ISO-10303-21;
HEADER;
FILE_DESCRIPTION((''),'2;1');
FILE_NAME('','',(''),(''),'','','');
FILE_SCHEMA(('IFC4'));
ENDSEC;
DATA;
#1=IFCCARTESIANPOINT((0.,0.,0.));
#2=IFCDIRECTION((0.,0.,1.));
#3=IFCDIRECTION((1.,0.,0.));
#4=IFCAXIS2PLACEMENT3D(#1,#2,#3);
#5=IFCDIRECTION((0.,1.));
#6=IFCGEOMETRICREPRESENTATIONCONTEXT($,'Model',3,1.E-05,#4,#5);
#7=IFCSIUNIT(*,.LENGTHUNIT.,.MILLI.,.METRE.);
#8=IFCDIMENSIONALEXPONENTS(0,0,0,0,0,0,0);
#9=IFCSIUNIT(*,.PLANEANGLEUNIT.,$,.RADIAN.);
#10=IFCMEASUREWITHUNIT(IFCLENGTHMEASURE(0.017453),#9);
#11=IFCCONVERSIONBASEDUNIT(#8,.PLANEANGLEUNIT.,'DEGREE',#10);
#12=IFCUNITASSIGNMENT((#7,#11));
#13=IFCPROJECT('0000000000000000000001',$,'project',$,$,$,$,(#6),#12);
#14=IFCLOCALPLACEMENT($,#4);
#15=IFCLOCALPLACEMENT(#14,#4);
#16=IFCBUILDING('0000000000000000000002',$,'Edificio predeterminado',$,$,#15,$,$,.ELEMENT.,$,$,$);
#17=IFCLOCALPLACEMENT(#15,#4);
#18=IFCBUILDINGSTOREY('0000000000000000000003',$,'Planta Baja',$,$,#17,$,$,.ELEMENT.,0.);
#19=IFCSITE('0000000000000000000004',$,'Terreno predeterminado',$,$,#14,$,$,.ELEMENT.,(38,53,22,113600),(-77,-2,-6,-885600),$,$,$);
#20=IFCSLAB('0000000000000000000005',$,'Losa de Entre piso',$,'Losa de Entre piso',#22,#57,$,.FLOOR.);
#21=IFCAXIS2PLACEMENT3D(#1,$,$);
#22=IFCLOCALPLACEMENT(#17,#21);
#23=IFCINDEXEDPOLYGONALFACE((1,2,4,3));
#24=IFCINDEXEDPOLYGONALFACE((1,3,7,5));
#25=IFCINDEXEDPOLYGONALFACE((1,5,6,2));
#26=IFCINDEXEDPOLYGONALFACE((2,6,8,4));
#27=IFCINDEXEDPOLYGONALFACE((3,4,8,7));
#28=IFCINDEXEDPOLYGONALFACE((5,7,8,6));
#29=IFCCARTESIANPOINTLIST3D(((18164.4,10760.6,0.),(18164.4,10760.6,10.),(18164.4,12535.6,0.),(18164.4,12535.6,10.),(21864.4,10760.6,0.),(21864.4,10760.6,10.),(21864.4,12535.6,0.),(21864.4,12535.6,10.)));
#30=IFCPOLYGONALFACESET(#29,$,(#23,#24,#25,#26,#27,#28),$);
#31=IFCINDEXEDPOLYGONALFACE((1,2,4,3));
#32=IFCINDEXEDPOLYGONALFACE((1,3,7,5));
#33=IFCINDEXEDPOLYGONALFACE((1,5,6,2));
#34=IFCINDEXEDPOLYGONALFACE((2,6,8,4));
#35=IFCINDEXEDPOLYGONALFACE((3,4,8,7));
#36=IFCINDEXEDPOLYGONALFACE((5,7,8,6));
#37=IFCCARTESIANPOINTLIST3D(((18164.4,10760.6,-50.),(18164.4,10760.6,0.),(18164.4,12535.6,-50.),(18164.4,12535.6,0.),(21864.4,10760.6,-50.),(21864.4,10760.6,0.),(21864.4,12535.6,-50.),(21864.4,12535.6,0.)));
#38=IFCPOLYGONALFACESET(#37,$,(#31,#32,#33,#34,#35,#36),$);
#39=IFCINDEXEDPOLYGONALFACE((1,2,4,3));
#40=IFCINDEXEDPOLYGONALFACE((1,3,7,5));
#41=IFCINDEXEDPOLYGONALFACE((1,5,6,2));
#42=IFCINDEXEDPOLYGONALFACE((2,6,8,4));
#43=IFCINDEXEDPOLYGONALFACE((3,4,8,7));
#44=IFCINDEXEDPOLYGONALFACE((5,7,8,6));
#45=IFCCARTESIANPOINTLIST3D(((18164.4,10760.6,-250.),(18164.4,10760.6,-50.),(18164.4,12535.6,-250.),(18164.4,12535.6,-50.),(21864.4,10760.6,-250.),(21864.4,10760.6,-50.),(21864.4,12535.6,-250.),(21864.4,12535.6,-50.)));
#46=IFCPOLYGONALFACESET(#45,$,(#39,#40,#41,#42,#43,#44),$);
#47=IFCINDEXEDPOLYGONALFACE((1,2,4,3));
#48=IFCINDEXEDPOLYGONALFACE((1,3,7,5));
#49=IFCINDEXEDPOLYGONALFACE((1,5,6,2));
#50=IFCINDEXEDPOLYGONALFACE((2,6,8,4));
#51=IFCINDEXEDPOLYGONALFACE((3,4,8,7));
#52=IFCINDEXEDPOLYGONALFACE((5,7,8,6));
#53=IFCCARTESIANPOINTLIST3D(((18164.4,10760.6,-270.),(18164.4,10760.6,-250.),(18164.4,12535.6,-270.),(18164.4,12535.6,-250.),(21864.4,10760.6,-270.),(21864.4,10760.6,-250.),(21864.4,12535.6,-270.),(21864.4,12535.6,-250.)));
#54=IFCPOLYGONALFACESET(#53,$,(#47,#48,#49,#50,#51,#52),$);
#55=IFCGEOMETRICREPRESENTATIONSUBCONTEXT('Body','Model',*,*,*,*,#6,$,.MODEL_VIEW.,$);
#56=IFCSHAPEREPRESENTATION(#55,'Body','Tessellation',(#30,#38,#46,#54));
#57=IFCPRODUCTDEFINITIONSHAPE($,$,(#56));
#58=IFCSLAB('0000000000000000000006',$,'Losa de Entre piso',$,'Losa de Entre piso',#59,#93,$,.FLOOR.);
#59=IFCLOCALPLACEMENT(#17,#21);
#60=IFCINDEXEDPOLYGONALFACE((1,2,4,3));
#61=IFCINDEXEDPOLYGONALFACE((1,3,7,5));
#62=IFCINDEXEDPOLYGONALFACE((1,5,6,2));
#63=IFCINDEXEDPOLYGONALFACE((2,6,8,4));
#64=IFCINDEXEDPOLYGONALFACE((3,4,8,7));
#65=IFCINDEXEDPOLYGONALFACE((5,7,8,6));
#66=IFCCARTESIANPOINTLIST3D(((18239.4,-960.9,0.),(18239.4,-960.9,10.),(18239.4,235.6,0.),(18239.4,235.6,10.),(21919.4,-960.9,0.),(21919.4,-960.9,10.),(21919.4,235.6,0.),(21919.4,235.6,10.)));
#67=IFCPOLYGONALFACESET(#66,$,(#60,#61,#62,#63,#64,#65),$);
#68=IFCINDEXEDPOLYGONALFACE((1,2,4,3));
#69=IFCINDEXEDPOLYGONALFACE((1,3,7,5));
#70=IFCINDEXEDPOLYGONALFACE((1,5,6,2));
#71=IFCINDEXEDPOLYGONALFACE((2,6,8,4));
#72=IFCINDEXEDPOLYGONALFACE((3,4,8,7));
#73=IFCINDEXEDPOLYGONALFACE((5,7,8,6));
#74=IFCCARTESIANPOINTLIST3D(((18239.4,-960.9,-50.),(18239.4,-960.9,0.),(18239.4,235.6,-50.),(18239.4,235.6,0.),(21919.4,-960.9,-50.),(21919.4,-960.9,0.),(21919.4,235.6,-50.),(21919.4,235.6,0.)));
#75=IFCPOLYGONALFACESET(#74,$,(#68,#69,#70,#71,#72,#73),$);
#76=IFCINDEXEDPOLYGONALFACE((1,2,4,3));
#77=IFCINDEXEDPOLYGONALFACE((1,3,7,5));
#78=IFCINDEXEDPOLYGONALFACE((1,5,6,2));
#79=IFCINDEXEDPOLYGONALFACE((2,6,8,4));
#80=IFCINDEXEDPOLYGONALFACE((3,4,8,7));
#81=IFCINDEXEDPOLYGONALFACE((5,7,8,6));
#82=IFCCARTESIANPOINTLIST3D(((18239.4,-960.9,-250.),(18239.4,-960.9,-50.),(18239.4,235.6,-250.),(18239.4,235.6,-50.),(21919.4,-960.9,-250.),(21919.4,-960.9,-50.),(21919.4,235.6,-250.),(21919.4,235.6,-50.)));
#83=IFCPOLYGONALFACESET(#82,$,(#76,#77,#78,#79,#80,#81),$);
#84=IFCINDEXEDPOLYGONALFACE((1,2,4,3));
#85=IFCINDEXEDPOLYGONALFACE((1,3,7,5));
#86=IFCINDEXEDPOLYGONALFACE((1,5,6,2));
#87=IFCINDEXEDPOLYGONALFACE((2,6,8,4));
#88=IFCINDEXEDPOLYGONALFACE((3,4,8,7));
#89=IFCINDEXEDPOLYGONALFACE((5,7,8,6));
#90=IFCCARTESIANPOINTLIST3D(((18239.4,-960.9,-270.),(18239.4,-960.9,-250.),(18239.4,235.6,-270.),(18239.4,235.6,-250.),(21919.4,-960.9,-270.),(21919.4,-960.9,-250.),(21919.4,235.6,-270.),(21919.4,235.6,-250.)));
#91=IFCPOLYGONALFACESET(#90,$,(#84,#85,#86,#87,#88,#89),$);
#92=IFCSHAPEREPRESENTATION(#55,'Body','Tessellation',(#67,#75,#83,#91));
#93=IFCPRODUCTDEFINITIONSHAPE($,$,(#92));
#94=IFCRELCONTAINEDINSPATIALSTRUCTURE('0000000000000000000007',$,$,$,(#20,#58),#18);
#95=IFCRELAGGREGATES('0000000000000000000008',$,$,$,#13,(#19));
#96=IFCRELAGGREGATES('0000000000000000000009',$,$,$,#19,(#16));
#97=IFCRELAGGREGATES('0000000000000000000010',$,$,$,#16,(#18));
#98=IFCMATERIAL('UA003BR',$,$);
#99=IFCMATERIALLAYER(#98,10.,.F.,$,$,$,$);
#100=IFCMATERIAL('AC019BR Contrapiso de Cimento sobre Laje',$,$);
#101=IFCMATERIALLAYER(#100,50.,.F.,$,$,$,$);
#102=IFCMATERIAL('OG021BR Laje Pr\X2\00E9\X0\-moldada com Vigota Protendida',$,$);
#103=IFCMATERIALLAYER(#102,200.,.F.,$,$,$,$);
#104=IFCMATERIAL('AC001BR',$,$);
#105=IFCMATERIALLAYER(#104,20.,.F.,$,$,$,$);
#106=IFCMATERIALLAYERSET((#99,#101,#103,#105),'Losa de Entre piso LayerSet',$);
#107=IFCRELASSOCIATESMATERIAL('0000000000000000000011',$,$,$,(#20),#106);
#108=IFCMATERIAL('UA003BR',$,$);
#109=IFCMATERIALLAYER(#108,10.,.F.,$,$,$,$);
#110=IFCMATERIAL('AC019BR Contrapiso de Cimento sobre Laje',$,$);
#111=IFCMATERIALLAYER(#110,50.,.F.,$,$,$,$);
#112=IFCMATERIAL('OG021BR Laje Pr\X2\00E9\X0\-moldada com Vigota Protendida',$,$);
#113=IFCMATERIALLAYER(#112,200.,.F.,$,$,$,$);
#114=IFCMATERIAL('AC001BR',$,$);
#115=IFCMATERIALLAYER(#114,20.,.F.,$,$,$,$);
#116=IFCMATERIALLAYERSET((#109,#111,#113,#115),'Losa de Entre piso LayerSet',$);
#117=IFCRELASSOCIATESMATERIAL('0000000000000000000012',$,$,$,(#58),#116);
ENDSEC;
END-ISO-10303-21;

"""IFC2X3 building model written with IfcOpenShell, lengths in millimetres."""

from ifc_helpers import new_model, entity, si_unit, converted_unit, direction, frame, origin_with_axes, place, context, subcontext, project, spatial, polyline, outline, extrude, material, layer, layer_set, layer_usage, element, save


model = new_model("IFC2X3")

# Units and contexts
model_context = context("Model", 3, precision=1e-05, world=origin_with_axes(), true_north=direction((0.0, 1.0)))
body_context = subcontext(model_context, "Body", "Model", "MODEL_VIEW")
ifc_project = project(units=[si_unit("LENGTHUNIT", "METRE", prefix="MILLI"), converted_unit("PLANEANGLEUNIT", "DEGREE", entity("IfcLengthMeasure", 0.017453), si_unit("PLANEANGLEUNIT", "RADIAN"), dimensions=[0, 0, 0, 0, 0, 0, 0])], contexts=[model_context])

# Site, building, storey
site_placement = place(None, origin_with_axes())
site = spatial("IfcSite", under=ifc_project, at=site_placement, Name="Terreno predeterminado", CompositionType="ELEMENT", RefLatitude=(38, 53, 22, 113600), RefLongitude=(-77, -2, -6, -885600))
building_placement = place(site_placement, origin_with_axes())
building = spatial("IfcBuilding", under=site, at=building_placement, Name="Edificio predeterminado", CompositionType="ELEMENT")
storey_placement = place(building_placement, origin_with_axes())
storey = spatial("IfcBuildingStorey", under=building, at=storey_placement, Name="Planta Baja", CompositionType="ELEMENT", Elevation=0.0)

# Slabs
ifc_material_1 = material(Name="UA003BR")
ifc_layer_1 = layer(ifc_material_1, 10.0, ventilated=False)
ifc_material_2 = material(Name="AC019BR Contrapiso de Cimento sobre Laje")
ifc_layer_2 = layer(ifc_material_2, 50.0, ventilated=False)
ifc_material_3 = material(Name="OG021BR Laje Pré-moldada com Vigota Protendida")
ifc_layer_3 = layer(ifc_material_3, 200.0, ventilated=False)
ifc_material_4 = material(Name="AC001BR")
ifc_layer_4 = layer(ifc_material_4, 20.0, ventilated=False)
ifc_layer_set_1 = layer_set([ifc_layer_1, ifc_layer_2, ifc_layer_3, ifc_layer_4], Name="Losa de Entre piso LayerSet")
ifc_layer_usage_1 = layer_usage(ifc_layer_set_1, "AXIS3", "POSITIVE", 0.0)
slab_1_placement = place(storey_placement, origin_with_axes())
element("IfcSlab", 1, at=slab_1_placement, inside=storey, material=ifc_layer_usage_1, Name="Losa de Entre piso", ObjectType="Losa de Entre piso", PredefinedType="FLOOR", context=body_context, shape_type="SweptSolid", body=[
    extrude(outline(polyline([(0.0, 0.0), (1775.0, 0.0), (1775.0, 3700.0), (0.0, 3700.0), (0.0, 0.0)])), frame((21864.4, 12535.6, 0.0), z_axis=(0.0, 0.0, -1.0), x_axis=(0.0, -1.0, 0.0)), (0.0, 0.0, -1.0), 10.0),
    extrude(outline(polyline([(0.0, 0.0), (1775.0, 0.0), (1775.0, 3700.0), (0.0, 3700.0), (0.0, 0.0)])), frame((21864.4, 12535.6, -50.0), z_axis=(0.0, 0.0, -1.0), x_axis=(0.0, -1.0, 0.0)), (0.0, 0.0, -1.0), 50.0),
    extrude(outline(polyline([(0.0, 0.0), (1775.0, 0.0), (1775.0, 3700.0), (0.0, 3700.0), (0.0, 0.0)])), frame((21864.4, 12535.6, -250.0), z_axis=(0.0, 0.0, -1.0), x_axis=(0.0, -1.0, 0.0)), (0.0, 0.0, -1.0), 200.0),
    extrude(outline(polyline([(0.0, 0.0), (1775.0, 0.0), (1775.0, 3700.0), (0.0, 3700.0), (0.0, 0.0)])), frame((21864.4, 12535.6, -270.0), z_axis=(0.0, 0.0, -1.0), x_axis=(0.0, -1.0, 0.0)), (0.0, 0.0, -1.0), 20.0),
])
ifc_material_5 = material(Name="UA003BR")
ifc_layer_5 = layer(ifc_material_5, 10.0, ventilated=False)
ifc_material_6 = material(Name="AC019BR Contrapiso de Cimento sobre Laje")
ifc_layer_6 = layer(ifc_material_6, 50.0, ventilated=False)
ifc_material_7 = material(Name="OG021BR Laje Pré-moldada com Vigota Protendida")
ifc_layer_7 = layer(ifc_material_7, 200.0, ventilated=False)
ifc_material_8 = material(Name="AC001BR")
ifc_layer_8 = layer(ifc_material_8, 20.0, ventilated=False)
ifc_layer_set_2 = layer_set([ifc_layer_5, ifc_layer_6, ifc_layer_7, ifc_layer_8], Name="Losa de Entre piso LayerSet")
ifc_layer_usage_2 = layer_usage(ifc_layer_set_2, "AXIS3", "POSITIVE", 0.0)
slab_2_placement = place(storey_placement, origin_with_axes())
element("IfcSlab", 2, at=slab_2_placement, inside=storey, material=ifc_layer_usage_2, Name="Losa de Entre piso", ObjectType="Losa de Entre piso", PredefinedType="FLOOR", context=body_context, shape_type="SweptSolid", body=[
    extrude(outline(polyline([(0.0, 0.0), (1196.6, 0.0), (1196.6, 3680.0), (0.0, 3680.0), (0.0, 0.0)])), frame((21919.4, 235.6, 0.0), z_axis=(0.0, 0.0, -1.0), x_axis=(0.0, -1.0, 0.0)), (0.0, 0.0, -1.0), 10.0),
    extrude(outline(polyline([(0.0, 0.0), (1196.6, 0.0), (1196.6, 3680.0), (0.0, 3680.0), (0.0, 0.0)])), frame((21919.4, 235.6, -50.0), z_axis=(0.0, 0.0, -1.0), x_axis=(0.0, -1.0, 0.0)), (0.0, 0.0, -1.0), 50.0),
    extrude(outline(polyline([(0.0, 0.0), (1196.6, 0.0), (1196.6, 3680.0), (0.0, 3680.0), (0.0, 0.0)])), frame((21919.4, 235.6, -250.0), z_axis=(0.0, 0.0, -1.0), x_axis=(0.0, -1.0, 0.0)), (0.0, 0.0, -1.0), 200.0),
    extrude(outline(polyline([(0.0, 0.0), (1196.6, 0.0), (1196.6, 3680.0), (0.0, 3680.0), (0.0, 0.0)])), frame((21919.4, 235.6, -270.0), z_axis=(0.0, 0.0, -1.0), x_axis=(0.0, -1.0, 0.0)), (0.0, 0.0, -1.0), 20.0),
])

save(model, "model.ifc")
